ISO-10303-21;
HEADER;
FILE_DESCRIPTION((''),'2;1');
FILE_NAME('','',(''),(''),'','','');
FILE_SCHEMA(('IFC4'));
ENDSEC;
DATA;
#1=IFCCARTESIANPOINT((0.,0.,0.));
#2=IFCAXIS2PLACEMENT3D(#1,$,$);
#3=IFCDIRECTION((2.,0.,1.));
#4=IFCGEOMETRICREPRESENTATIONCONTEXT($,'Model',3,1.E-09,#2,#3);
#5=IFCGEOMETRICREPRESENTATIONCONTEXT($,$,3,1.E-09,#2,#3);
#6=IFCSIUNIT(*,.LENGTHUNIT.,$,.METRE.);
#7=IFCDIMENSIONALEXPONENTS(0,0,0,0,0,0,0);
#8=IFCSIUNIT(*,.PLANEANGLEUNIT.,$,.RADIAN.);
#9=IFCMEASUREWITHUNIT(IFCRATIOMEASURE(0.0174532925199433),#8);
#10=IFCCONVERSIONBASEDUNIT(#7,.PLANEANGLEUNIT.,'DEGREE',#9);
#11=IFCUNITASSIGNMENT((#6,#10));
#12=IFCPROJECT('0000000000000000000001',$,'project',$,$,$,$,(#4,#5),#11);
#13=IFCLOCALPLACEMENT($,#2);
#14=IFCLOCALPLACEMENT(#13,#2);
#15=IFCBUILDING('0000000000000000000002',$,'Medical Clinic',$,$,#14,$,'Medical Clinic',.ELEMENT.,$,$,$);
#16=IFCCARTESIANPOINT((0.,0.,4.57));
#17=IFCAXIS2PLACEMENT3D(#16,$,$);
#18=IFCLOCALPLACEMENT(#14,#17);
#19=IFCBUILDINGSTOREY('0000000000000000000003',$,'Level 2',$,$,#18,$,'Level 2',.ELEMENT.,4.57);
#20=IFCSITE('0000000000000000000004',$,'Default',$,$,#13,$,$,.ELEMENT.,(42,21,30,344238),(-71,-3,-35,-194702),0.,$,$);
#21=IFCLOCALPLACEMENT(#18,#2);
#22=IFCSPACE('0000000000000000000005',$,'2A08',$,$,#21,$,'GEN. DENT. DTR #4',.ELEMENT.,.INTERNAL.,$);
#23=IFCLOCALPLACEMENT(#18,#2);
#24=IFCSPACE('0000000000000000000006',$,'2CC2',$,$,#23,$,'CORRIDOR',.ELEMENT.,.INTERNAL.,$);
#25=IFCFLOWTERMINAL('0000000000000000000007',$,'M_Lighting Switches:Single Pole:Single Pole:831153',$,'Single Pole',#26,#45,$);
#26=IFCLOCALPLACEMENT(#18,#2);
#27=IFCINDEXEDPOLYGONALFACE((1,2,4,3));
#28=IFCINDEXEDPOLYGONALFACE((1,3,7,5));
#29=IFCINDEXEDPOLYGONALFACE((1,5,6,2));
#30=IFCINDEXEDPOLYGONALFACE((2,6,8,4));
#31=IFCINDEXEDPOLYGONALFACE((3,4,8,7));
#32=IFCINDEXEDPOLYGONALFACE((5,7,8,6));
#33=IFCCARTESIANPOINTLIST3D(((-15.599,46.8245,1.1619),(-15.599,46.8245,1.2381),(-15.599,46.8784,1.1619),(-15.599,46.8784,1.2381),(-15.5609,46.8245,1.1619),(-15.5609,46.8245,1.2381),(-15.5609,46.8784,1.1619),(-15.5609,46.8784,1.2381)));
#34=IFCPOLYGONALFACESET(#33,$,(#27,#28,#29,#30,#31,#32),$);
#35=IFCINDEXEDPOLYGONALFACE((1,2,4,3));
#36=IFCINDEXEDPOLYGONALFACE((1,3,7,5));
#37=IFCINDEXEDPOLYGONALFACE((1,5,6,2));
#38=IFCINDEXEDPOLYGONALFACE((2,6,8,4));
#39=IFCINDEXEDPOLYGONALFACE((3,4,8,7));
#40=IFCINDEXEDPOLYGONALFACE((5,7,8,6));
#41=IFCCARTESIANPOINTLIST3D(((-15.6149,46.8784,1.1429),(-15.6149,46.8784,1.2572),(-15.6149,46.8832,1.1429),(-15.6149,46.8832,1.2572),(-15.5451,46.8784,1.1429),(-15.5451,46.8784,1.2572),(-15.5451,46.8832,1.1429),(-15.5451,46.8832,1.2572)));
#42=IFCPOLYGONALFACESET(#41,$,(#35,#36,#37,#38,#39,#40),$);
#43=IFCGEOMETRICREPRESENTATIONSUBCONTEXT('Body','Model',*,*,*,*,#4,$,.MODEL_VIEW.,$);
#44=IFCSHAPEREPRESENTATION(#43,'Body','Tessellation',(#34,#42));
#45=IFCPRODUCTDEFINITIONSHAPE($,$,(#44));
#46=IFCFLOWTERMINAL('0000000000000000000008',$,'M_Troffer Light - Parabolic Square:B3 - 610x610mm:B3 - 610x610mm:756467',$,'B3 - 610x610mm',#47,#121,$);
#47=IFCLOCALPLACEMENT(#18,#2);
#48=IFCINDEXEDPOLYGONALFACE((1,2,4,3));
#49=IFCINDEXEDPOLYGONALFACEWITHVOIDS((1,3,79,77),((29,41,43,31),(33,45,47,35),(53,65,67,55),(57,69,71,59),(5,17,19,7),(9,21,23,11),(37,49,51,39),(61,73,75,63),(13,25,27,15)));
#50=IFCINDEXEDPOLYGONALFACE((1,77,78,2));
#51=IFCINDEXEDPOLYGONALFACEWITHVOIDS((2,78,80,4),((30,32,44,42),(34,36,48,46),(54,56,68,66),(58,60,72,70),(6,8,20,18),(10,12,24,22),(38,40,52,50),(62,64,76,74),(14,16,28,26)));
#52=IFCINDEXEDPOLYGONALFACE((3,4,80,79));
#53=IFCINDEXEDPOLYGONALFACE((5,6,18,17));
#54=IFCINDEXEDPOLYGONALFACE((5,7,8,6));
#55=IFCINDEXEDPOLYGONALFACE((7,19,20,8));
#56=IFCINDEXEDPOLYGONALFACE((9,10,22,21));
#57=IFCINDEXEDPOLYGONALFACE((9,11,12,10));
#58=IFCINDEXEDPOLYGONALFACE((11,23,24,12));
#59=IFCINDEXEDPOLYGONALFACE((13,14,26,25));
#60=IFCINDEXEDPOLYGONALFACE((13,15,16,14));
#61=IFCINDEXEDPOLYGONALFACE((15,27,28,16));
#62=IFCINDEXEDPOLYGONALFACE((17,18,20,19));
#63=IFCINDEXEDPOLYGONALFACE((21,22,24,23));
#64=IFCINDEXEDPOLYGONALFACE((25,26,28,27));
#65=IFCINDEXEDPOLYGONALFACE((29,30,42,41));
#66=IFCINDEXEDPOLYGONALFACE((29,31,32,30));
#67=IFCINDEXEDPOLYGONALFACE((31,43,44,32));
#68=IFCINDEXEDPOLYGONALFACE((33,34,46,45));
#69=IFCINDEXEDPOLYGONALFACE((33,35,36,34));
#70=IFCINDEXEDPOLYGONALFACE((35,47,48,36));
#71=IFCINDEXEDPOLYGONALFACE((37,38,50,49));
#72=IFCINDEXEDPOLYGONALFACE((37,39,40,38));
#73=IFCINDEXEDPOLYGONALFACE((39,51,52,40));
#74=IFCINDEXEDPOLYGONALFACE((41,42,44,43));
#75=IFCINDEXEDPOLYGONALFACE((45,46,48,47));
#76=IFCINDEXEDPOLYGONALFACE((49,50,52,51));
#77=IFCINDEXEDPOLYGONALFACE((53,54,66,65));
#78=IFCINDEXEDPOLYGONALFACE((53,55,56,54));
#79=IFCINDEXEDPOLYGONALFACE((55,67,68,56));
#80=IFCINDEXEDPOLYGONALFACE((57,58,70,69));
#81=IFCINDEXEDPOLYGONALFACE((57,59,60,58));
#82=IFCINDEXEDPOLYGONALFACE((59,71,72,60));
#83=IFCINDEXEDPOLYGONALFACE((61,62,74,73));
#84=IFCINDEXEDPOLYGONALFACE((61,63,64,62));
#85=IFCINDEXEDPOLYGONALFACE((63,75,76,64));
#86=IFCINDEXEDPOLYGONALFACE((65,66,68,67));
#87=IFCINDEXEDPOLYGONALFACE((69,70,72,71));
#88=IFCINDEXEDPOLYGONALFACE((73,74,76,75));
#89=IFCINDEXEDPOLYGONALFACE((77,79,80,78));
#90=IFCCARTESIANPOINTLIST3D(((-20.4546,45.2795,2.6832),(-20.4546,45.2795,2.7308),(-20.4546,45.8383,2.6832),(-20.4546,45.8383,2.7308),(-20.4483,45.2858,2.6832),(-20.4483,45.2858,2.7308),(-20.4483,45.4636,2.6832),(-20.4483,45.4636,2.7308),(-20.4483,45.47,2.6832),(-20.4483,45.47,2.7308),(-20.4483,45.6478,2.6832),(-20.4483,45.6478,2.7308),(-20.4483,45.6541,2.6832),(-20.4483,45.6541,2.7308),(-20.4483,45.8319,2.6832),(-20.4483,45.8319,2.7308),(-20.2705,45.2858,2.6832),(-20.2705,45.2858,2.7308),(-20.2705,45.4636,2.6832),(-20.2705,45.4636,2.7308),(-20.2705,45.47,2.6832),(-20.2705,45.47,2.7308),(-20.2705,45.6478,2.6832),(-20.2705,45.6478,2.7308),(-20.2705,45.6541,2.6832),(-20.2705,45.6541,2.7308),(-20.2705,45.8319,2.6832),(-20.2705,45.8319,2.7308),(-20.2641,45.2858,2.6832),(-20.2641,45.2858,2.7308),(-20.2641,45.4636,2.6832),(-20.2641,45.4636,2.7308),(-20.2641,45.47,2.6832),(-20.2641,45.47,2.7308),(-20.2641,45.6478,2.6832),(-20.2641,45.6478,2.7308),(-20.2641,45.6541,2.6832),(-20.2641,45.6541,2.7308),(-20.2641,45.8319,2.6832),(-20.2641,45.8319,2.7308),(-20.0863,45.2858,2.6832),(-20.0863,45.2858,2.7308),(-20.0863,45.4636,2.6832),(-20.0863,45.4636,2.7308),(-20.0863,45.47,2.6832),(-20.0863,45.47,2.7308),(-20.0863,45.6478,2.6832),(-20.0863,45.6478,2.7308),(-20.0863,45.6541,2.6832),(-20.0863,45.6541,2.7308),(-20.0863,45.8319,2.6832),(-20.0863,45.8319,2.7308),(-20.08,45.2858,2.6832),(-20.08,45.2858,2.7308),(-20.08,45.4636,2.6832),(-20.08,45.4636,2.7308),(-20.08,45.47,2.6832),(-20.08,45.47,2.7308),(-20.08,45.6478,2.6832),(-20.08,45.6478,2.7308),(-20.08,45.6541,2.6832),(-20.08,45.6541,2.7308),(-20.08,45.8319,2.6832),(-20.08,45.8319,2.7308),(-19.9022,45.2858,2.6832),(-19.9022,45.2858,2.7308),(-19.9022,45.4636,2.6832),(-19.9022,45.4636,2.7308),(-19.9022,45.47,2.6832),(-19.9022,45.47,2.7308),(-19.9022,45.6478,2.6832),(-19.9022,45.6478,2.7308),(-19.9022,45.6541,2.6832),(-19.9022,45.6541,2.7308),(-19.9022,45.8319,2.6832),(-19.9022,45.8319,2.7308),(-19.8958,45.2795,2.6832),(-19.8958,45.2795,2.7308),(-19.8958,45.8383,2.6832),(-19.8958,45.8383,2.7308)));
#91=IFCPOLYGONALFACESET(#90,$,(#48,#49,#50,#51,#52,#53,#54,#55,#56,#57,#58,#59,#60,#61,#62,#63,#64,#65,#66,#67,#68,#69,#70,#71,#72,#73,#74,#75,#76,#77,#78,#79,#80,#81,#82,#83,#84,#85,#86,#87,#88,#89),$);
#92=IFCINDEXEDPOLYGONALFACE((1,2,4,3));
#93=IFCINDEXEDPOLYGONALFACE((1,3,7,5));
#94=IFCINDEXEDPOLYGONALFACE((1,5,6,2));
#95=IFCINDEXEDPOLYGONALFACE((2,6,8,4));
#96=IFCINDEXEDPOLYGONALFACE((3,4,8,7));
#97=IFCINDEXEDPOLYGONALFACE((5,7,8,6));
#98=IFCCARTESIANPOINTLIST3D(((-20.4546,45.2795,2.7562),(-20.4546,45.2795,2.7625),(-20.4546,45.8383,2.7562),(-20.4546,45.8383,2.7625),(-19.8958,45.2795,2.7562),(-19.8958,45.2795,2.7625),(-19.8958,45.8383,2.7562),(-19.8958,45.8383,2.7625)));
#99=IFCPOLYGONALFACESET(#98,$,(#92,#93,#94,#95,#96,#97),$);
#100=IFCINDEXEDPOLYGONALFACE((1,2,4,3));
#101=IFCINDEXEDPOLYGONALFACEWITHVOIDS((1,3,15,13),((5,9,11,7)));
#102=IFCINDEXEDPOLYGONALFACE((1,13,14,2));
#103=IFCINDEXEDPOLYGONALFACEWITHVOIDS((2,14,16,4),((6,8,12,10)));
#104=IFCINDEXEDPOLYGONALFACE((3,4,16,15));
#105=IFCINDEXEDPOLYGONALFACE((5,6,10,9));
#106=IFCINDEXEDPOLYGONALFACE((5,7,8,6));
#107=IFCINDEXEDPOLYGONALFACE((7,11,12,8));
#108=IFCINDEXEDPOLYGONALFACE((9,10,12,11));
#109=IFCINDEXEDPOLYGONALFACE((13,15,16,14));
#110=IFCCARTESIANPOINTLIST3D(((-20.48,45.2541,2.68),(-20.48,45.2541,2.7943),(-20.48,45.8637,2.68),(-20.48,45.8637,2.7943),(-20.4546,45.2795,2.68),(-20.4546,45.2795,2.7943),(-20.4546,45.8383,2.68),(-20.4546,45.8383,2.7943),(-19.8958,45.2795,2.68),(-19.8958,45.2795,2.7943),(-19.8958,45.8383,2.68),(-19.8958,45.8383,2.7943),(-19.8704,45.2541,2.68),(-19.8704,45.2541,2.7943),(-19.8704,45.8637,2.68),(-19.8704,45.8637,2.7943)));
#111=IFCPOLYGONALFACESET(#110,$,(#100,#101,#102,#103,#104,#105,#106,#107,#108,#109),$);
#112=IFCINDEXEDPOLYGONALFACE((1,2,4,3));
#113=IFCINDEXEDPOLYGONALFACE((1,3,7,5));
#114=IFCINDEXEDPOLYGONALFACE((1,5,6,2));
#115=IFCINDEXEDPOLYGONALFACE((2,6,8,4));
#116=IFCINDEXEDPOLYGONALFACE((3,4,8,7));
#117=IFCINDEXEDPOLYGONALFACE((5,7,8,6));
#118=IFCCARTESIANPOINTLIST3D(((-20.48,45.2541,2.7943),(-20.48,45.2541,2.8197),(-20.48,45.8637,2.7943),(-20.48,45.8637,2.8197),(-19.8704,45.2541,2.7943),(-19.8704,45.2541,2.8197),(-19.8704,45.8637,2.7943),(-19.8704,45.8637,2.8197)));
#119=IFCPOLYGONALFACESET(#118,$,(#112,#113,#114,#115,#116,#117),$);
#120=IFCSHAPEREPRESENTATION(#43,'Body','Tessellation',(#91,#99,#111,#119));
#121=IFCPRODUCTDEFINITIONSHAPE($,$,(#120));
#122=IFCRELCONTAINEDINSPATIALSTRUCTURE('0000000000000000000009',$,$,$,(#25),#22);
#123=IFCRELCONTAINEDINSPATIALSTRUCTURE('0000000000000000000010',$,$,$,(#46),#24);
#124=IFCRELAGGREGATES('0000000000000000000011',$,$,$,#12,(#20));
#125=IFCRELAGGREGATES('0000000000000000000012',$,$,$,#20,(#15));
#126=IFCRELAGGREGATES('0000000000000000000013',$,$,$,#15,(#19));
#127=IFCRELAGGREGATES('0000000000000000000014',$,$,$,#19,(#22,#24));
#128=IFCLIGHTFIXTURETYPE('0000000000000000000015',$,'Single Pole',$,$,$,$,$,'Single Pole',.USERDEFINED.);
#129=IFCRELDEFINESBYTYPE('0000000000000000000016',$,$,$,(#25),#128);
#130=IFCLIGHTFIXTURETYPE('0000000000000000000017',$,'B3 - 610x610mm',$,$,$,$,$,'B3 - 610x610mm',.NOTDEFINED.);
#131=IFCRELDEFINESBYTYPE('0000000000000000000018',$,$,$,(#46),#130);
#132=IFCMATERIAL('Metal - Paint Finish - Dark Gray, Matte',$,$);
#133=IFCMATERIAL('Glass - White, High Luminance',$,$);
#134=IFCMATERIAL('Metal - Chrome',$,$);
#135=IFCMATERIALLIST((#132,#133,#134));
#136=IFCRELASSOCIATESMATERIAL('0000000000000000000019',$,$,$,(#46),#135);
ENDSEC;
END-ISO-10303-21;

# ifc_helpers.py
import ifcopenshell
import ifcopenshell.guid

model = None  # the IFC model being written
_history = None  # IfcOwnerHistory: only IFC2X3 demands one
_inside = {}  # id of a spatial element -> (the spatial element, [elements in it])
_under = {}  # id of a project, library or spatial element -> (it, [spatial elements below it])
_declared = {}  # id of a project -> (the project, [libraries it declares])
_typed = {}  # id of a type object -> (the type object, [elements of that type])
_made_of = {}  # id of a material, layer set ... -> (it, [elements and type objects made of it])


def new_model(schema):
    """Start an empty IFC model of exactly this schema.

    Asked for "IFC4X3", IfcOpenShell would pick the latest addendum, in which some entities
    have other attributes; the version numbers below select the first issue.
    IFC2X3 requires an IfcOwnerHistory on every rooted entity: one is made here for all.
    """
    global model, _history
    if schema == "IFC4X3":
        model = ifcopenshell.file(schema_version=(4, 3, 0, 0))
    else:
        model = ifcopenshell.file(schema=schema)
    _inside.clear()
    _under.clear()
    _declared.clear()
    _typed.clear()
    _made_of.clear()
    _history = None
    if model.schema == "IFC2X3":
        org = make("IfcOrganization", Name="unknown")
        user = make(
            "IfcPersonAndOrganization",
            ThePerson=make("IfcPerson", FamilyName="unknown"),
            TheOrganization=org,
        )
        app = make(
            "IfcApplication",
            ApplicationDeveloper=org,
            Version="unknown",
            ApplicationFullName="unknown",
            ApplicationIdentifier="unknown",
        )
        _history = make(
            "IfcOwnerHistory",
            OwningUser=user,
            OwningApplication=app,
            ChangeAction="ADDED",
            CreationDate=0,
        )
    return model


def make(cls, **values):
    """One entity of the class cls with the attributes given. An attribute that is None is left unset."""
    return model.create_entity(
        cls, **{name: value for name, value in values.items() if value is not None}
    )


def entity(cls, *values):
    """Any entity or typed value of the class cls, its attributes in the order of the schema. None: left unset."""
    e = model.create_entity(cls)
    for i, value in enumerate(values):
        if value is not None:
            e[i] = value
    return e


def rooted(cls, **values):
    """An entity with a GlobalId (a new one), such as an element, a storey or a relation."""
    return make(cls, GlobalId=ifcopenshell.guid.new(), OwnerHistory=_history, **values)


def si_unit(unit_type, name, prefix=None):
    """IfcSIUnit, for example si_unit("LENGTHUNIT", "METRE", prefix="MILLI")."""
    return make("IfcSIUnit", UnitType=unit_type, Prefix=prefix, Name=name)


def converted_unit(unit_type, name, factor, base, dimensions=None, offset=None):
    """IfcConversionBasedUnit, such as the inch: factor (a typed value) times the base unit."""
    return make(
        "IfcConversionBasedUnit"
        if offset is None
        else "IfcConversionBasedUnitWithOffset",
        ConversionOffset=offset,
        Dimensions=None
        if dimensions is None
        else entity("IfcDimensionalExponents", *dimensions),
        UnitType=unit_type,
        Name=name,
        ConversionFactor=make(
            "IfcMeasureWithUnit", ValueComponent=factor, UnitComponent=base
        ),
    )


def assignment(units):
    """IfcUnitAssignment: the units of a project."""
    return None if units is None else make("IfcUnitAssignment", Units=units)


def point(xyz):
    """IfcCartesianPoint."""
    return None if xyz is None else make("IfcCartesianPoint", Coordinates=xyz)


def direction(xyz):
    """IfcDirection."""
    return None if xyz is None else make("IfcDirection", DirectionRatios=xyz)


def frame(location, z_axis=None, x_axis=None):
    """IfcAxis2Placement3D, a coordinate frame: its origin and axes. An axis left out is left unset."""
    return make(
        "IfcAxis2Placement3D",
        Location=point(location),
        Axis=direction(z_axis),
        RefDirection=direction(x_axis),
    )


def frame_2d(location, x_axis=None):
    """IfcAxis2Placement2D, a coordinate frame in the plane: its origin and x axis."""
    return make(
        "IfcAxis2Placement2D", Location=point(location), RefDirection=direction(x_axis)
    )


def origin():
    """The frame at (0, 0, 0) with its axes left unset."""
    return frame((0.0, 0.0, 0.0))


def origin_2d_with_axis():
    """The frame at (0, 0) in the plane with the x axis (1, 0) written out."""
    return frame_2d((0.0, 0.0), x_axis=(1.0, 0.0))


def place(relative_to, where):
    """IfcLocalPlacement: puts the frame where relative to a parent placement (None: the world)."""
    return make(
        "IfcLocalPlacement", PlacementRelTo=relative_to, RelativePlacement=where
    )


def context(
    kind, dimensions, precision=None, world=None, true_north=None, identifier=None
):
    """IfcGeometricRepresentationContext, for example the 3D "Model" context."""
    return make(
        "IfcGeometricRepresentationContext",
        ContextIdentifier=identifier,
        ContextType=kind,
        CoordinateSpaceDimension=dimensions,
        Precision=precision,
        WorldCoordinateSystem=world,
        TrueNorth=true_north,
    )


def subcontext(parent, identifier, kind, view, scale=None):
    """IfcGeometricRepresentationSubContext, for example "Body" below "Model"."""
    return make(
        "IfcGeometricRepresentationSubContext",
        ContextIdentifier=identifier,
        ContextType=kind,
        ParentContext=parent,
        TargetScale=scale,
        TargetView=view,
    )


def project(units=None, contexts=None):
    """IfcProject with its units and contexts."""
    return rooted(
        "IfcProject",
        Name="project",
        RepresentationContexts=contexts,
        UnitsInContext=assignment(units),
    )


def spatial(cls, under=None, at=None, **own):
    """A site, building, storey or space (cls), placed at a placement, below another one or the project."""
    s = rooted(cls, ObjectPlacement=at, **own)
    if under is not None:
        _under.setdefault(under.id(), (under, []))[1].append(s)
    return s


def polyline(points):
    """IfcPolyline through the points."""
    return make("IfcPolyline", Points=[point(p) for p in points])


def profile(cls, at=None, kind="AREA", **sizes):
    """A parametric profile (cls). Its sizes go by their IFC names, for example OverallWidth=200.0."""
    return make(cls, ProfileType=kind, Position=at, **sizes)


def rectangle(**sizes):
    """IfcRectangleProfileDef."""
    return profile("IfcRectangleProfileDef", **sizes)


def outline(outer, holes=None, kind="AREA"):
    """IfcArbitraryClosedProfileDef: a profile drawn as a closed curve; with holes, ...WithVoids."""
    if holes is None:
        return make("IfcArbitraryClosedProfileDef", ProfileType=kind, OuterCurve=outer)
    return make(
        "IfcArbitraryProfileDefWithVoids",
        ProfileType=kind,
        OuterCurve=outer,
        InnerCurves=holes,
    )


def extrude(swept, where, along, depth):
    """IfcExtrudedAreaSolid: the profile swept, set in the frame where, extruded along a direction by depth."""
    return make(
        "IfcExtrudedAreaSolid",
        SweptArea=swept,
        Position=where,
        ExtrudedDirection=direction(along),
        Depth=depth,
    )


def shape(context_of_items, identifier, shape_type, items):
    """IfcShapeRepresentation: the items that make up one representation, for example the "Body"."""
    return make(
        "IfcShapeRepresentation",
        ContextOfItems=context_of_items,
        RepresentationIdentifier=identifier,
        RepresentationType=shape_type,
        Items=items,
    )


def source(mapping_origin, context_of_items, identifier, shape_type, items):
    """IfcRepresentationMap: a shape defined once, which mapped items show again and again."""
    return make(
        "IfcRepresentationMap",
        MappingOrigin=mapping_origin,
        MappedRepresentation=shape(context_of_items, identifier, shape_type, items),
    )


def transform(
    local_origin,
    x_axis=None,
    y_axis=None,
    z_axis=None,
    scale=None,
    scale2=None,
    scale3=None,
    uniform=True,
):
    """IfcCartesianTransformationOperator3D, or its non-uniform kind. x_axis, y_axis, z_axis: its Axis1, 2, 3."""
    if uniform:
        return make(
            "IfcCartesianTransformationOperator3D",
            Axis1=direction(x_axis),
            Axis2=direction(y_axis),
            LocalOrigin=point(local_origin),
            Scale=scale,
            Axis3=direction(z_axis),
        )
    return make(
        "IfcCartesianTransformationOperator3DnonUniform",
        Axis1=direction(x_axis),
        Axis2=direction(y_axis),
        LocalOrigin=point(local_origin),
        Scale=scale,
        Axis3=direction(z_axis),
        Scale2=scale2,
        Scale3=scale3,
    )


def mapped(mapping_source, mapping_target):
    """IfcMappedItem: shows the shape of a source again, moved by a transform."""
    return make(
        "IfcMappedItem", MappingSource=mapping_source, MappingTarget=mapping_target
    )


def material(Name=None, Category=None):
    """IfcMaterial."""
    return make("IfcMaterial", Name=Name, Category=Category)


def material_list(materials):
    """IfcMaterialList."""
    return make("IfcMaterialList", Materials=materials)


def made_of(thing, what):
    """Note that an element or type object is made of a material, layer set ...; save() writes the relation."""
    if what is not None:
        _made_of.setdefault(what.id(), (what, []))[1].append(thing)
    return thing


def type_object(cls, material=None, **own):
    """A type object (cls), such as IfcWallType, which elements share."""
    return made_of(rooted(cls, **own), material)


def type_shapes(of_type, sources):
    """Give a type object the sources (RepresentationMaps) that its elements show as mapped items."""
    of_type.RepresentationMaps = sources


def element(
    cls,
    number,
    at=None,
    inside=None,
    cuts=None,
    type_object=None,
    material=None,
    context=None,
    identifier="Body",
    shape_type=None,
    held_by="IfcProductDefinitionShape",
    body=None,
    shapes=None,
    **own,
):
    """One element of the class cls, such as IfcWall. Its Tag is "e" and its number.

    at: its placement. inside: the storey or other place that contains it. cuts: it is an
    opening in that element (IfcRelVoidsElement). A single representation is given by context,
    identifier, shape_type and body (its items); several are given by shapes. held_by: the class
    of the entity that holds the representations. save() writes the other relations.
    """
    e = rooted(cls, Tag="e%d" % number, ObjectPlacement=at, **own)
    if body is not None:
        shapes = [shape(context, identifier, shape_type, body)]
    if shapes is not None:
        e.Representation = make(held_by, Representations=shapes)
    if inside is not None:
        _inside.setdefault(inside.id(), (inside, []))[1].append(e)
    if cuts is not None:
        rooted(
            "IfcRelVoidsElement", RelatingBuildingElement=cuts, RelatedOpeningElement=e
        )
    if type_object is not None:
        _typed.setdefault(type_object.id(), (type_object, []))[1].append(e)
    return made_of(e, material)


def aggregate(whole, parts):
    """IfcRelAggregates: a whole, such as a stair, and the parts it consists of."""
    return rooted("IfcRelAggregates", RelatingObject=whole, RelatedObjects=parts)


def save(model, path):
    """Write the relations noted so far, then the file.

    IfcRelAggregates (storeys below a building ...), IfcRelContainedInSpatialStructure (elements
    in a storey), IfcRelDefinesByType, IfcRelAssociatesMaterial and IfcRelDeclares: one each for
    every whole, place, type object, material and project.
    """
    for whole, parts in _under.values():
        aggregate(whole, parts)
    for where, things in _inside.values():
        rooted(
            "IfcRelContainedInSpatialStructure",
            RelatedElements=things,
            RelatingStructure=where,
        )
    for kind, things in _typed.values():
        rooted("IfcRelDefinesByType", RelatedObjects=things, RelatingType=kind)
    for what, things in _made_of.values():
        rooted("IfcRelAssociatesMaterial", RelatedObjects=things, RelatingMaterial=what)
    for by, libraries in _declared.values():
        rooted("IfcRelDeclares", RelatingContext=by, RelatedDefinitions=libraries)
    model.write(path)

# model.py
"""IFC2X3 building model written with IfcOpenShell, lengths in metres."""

from ifc_helpers import new_model, entity, si_unit, converted_unit, direction, frame, frame_2d, origin, origin_2d_with_axis, place, context, subcontext, project, spatial, polyline, rectangle, outline, extrude, source, transform, mapped, material, material_list, type_object, type_shapes, element, save


model = new_model("IFC2X3")

# Units and contexts
model_context = context("Model", 3, precision=1e-09, world=origin(), true_north=direction((2.0, 0.0, 1.0)))
context_of_model = context(None, 3, precision=1e-09, world=origin(), true_north=direction((2.0, 0.0, 1.0)))
body_context = subcontext(model_context, "Body", "Model", "MODEL_VIEW")
ifc_project = project(units=[si_unit("LENGTHUNIT", "METRE"), converted_unit("PLANEANGLEUNIT", "DEGREE", entity("IfcRatioMeasure", 0.0174532925199433), si_unit("PLANEANGLEUNIT", "RADIAN"), dimensions=[0, 0, 0, 0, 0, 0, 0])], contexts=[model_context, context_of_model])

# Site, building, storey
site_placement = place(None, origin())
site = spatial("IfcSite", under=ifc_project, at=site_placement, Name="Default", CompositionType="ELEMENT", RefLatitude=(42, 21, 30, 344238), RefLongitude=(-71, -3, -35, -194702), RefElevation=0.0)
building_placement = place(site_placement, origin())
building = spatial("IfcBuilding", under=site, at=building_placement, Name="Medical Clinic", LongName="Medical Clinic", CompositionType="ELEMENT")
storey_placement = place(building_placement, frame((0.0, 0.0, 4.57)))
storey = spatial("IfcBuildingStorey", under=building, at=storey_placement, Name="Level 2", LongName="Level 2", CompositionType="ELEMENT", Elevation=4.57)

# Shared definitions
space_1_placement = place(storey_placement, origin())
space_1 = spatial("IfcSpace", under=storey, at=space_1_placement, Name="2A08", LongName="GEN. DENT. DTR #4", CompositionType="ELEMENT", InteriorOrExteriorSpace="INTERNAL")

# Shared definitions
light_fixture_type_1 = type_object("IfcLightFixtureType", Name="Single Pole", ElementType="Single Pole", PredefinedType="USERDEFINED")
shared_shape_1 = source(origin(), body_context, "Body", "SweptSolid", [
    extrude(rectangle(XDim=0.0381, YDim=0.0762, at=origin_2d_with_axis()), frame((0.0, 0.0, -0.054), z_axis=(0.0, 0.0, 1.0), x_axis=(-1.0, 0.0, 0.0)), (0.0, 0.0, 1.0), 0.054),
    extrude(rectangle(XDim=0.0698, YDim=0.1143, at=frame_2d((0.0, 0.0), x_axis=(1.0, 0.0))), frame((0.0, 0.0, 0.0), z_axis=(0.0, 0.0, 1.0), x_axis=(-1.0, 0.0, 0.0)), (0.0, 0.0, 1.0), 0.0048),
])
type_shapes(light_fixture_type_1, [shared_shape_1])

# Flow terminal
flow_terminal_1_placement = place(space_1_placement, frame((-15.58, 46.8784, 1.2), z_axis=(0.0, 1.0, 0.0), x_axis=(-1.0, 0.0, 0.0)))
element("IfcFlowTerminal", 1, at=flow_terminal_1_placement, inside=space_1, type_object=light_fixture_type_1, Name="M_Lighting Switches:Single Pole:Single Pole:831153", ObjectType="Single Pole", context=body_context, shape_type="MappedRepresentation", body=[
    mapped(shared_shape_1, transform((0.0, 0.0, 0.0), scale=1.0)),
])

# Shared definitions
space_2_placement = place(storey_placement, origin())
space_2 = spatial("IfcSpace", under=storey, at=space_2_placement, Name="2CC2", LongName="CORRIDOR", CompositionType="ELEMENT", InteriorOrExteriorSpace="INTERNAL")

# Flow terminal
ifc_material_1 = material(Name="Metal - Paint Finish - Dark Gray, Matte")
ifc_material_2 = material(Name="Glass - White, High Luminance")
ifc_material_3 = material(Name="Metal - Chrome")
ifc_material_list = material_list([ifc_material_1, ifc_material_2, ifc_material_3])
light_fixture_type_2 = type_object("IfcLightFixtureType", Name="B3 - 610x610mm", ElementType="B3 - 610x610mm", PredefinedType="NOTDEFINED")
shared_shape_2 = source(origin(), body_context, "Body", "SweptSolid", [
    extrude(outline(polyline([(-0.2794, -0.2794), (0.2794, -0.2794), (0.2794, 0.2794), (-0.2794, 0.2794), (-0.2794, -0.2794)]), holes=[polyline([(-0.0952, 0.0953), (-0.273, 0.0953), (-0.273, 0.2731), (-0.0952, 0.2731), (-0.0952, 0.0953)]), polyline([(0.2731, 0.0953), (0.0953, 0.0953), (0.0953, 0.2731), (0.2731, 0.2731), (0.2731, 0.0953)]), polyline([(-0.0889, 0.2731), (0.0889, 0.2731), (0.0889, 0.0953), (-0.0889, 0.0953), (-0.0889, 0.2731)]), polyline([(0.2731, -0.273), (0.0953, -0.273), (0.0953, -0.0952), (0.2731, -0.0952), (0.2731, -0.273)]), polyline([(0.0889, -0.273), (-0.0889, -0.273), (-0.0889, -0.0952), (0.0889, -0.0952), (0.0889, -0.273)]), polyline([(-0.0952, -0.273), (-0.273, -0.273), (-0.273, -0.0952), (-0.0952, -0.0952), (-0.0952, -0.273)]), polyline([(-0.0952, -0.0889), (-0.273, -0.0889), (-0.273, 0.0889), (-0.0952, 0.0889), (-0.0952, -0.0889)]), polyline([(0.0889, -0.0889), (-0.0889, -0.0889), (-0.0889, 0.0889), (0.0889, 0.0889), (0.0889, -0.0889)]), polyline([(0.2731, -0.0889), (0.0953, -0.0889), (0.0953, 0.0889), (0.2731, 0.0889), (0.2731, -0.0889)])]), frame((0.0, -0.3048, -0.0508), z_axis=(0.0, 0.0, 1.0), x_axis=(-1.0, 0.0, 0.0)), (0.0, 0.0, 1.0), 0.0476),
    extrude(rectangle(XDim=0.5588, YDim=0.5588, at=origin_2d_with_axis()), frame((0.0, -0.3048, -0.0825), z_axis=(0.0, 0.0, 1.0), x_axis=(-1.0, 0.0, 0.0)), (0.0, 0.0, 1.0), 0.0064),
    extrude(outline(polyline([(-0.3048, -0.3048), (0.3048, -0.3048), (0.3048, 0.3048), (-0.3048, 0.3048), (-0.3048, -0.3048)]), holes=[polyline([(0.2794, 0.2794), (0.2794, -0.2794), (-0.2794, -0.2794), (-0.2794, 0.2794), (0.2794, 0.2794)])]), frame((0.0, -0.3048, -0.1143)), (0.0, 0.0, 1.0), 0.1143),
    extrude(rectangle(XDim=0.6096, YDim=0.6096, at=origin_2d_with_axis()), frame((0.0, -0.3048, -0.1397), z_axis=(0.0, 0.0, 1.0), x_axis=(-1.0, 0.0, 0.0)), (0.0, 0.0, 1.0), 0.0254),
])
type_shapes(light_fixture_type_2, [shared_shape_2])
flow_terminal_2_placement = place(space_2_placement, frame((-20.1752, 45.2541, 2.68), z_axis=(0.0, 0.0, -1.0), x_axis=(1.0, 0.0, 0.0)))
element("IfcFlowTerminal", 2, at=flow_terminal_2_placement, inside=space_2, type_object=light_fixture_type_2, material=ifc_material_list, Name="M_Troffer Light - Parabolic Square:B3 - 610x610mm:B3 - 610x610mm:756467", ObjectType="B3 - 610x610mm", context=body_context, shape_type="MappedRepresentation", body=[
    mapped(shared_shape_2, transform((0.0, 0.0, 0.0), scale=1.0)),
])

save(model, "model.ifc")
